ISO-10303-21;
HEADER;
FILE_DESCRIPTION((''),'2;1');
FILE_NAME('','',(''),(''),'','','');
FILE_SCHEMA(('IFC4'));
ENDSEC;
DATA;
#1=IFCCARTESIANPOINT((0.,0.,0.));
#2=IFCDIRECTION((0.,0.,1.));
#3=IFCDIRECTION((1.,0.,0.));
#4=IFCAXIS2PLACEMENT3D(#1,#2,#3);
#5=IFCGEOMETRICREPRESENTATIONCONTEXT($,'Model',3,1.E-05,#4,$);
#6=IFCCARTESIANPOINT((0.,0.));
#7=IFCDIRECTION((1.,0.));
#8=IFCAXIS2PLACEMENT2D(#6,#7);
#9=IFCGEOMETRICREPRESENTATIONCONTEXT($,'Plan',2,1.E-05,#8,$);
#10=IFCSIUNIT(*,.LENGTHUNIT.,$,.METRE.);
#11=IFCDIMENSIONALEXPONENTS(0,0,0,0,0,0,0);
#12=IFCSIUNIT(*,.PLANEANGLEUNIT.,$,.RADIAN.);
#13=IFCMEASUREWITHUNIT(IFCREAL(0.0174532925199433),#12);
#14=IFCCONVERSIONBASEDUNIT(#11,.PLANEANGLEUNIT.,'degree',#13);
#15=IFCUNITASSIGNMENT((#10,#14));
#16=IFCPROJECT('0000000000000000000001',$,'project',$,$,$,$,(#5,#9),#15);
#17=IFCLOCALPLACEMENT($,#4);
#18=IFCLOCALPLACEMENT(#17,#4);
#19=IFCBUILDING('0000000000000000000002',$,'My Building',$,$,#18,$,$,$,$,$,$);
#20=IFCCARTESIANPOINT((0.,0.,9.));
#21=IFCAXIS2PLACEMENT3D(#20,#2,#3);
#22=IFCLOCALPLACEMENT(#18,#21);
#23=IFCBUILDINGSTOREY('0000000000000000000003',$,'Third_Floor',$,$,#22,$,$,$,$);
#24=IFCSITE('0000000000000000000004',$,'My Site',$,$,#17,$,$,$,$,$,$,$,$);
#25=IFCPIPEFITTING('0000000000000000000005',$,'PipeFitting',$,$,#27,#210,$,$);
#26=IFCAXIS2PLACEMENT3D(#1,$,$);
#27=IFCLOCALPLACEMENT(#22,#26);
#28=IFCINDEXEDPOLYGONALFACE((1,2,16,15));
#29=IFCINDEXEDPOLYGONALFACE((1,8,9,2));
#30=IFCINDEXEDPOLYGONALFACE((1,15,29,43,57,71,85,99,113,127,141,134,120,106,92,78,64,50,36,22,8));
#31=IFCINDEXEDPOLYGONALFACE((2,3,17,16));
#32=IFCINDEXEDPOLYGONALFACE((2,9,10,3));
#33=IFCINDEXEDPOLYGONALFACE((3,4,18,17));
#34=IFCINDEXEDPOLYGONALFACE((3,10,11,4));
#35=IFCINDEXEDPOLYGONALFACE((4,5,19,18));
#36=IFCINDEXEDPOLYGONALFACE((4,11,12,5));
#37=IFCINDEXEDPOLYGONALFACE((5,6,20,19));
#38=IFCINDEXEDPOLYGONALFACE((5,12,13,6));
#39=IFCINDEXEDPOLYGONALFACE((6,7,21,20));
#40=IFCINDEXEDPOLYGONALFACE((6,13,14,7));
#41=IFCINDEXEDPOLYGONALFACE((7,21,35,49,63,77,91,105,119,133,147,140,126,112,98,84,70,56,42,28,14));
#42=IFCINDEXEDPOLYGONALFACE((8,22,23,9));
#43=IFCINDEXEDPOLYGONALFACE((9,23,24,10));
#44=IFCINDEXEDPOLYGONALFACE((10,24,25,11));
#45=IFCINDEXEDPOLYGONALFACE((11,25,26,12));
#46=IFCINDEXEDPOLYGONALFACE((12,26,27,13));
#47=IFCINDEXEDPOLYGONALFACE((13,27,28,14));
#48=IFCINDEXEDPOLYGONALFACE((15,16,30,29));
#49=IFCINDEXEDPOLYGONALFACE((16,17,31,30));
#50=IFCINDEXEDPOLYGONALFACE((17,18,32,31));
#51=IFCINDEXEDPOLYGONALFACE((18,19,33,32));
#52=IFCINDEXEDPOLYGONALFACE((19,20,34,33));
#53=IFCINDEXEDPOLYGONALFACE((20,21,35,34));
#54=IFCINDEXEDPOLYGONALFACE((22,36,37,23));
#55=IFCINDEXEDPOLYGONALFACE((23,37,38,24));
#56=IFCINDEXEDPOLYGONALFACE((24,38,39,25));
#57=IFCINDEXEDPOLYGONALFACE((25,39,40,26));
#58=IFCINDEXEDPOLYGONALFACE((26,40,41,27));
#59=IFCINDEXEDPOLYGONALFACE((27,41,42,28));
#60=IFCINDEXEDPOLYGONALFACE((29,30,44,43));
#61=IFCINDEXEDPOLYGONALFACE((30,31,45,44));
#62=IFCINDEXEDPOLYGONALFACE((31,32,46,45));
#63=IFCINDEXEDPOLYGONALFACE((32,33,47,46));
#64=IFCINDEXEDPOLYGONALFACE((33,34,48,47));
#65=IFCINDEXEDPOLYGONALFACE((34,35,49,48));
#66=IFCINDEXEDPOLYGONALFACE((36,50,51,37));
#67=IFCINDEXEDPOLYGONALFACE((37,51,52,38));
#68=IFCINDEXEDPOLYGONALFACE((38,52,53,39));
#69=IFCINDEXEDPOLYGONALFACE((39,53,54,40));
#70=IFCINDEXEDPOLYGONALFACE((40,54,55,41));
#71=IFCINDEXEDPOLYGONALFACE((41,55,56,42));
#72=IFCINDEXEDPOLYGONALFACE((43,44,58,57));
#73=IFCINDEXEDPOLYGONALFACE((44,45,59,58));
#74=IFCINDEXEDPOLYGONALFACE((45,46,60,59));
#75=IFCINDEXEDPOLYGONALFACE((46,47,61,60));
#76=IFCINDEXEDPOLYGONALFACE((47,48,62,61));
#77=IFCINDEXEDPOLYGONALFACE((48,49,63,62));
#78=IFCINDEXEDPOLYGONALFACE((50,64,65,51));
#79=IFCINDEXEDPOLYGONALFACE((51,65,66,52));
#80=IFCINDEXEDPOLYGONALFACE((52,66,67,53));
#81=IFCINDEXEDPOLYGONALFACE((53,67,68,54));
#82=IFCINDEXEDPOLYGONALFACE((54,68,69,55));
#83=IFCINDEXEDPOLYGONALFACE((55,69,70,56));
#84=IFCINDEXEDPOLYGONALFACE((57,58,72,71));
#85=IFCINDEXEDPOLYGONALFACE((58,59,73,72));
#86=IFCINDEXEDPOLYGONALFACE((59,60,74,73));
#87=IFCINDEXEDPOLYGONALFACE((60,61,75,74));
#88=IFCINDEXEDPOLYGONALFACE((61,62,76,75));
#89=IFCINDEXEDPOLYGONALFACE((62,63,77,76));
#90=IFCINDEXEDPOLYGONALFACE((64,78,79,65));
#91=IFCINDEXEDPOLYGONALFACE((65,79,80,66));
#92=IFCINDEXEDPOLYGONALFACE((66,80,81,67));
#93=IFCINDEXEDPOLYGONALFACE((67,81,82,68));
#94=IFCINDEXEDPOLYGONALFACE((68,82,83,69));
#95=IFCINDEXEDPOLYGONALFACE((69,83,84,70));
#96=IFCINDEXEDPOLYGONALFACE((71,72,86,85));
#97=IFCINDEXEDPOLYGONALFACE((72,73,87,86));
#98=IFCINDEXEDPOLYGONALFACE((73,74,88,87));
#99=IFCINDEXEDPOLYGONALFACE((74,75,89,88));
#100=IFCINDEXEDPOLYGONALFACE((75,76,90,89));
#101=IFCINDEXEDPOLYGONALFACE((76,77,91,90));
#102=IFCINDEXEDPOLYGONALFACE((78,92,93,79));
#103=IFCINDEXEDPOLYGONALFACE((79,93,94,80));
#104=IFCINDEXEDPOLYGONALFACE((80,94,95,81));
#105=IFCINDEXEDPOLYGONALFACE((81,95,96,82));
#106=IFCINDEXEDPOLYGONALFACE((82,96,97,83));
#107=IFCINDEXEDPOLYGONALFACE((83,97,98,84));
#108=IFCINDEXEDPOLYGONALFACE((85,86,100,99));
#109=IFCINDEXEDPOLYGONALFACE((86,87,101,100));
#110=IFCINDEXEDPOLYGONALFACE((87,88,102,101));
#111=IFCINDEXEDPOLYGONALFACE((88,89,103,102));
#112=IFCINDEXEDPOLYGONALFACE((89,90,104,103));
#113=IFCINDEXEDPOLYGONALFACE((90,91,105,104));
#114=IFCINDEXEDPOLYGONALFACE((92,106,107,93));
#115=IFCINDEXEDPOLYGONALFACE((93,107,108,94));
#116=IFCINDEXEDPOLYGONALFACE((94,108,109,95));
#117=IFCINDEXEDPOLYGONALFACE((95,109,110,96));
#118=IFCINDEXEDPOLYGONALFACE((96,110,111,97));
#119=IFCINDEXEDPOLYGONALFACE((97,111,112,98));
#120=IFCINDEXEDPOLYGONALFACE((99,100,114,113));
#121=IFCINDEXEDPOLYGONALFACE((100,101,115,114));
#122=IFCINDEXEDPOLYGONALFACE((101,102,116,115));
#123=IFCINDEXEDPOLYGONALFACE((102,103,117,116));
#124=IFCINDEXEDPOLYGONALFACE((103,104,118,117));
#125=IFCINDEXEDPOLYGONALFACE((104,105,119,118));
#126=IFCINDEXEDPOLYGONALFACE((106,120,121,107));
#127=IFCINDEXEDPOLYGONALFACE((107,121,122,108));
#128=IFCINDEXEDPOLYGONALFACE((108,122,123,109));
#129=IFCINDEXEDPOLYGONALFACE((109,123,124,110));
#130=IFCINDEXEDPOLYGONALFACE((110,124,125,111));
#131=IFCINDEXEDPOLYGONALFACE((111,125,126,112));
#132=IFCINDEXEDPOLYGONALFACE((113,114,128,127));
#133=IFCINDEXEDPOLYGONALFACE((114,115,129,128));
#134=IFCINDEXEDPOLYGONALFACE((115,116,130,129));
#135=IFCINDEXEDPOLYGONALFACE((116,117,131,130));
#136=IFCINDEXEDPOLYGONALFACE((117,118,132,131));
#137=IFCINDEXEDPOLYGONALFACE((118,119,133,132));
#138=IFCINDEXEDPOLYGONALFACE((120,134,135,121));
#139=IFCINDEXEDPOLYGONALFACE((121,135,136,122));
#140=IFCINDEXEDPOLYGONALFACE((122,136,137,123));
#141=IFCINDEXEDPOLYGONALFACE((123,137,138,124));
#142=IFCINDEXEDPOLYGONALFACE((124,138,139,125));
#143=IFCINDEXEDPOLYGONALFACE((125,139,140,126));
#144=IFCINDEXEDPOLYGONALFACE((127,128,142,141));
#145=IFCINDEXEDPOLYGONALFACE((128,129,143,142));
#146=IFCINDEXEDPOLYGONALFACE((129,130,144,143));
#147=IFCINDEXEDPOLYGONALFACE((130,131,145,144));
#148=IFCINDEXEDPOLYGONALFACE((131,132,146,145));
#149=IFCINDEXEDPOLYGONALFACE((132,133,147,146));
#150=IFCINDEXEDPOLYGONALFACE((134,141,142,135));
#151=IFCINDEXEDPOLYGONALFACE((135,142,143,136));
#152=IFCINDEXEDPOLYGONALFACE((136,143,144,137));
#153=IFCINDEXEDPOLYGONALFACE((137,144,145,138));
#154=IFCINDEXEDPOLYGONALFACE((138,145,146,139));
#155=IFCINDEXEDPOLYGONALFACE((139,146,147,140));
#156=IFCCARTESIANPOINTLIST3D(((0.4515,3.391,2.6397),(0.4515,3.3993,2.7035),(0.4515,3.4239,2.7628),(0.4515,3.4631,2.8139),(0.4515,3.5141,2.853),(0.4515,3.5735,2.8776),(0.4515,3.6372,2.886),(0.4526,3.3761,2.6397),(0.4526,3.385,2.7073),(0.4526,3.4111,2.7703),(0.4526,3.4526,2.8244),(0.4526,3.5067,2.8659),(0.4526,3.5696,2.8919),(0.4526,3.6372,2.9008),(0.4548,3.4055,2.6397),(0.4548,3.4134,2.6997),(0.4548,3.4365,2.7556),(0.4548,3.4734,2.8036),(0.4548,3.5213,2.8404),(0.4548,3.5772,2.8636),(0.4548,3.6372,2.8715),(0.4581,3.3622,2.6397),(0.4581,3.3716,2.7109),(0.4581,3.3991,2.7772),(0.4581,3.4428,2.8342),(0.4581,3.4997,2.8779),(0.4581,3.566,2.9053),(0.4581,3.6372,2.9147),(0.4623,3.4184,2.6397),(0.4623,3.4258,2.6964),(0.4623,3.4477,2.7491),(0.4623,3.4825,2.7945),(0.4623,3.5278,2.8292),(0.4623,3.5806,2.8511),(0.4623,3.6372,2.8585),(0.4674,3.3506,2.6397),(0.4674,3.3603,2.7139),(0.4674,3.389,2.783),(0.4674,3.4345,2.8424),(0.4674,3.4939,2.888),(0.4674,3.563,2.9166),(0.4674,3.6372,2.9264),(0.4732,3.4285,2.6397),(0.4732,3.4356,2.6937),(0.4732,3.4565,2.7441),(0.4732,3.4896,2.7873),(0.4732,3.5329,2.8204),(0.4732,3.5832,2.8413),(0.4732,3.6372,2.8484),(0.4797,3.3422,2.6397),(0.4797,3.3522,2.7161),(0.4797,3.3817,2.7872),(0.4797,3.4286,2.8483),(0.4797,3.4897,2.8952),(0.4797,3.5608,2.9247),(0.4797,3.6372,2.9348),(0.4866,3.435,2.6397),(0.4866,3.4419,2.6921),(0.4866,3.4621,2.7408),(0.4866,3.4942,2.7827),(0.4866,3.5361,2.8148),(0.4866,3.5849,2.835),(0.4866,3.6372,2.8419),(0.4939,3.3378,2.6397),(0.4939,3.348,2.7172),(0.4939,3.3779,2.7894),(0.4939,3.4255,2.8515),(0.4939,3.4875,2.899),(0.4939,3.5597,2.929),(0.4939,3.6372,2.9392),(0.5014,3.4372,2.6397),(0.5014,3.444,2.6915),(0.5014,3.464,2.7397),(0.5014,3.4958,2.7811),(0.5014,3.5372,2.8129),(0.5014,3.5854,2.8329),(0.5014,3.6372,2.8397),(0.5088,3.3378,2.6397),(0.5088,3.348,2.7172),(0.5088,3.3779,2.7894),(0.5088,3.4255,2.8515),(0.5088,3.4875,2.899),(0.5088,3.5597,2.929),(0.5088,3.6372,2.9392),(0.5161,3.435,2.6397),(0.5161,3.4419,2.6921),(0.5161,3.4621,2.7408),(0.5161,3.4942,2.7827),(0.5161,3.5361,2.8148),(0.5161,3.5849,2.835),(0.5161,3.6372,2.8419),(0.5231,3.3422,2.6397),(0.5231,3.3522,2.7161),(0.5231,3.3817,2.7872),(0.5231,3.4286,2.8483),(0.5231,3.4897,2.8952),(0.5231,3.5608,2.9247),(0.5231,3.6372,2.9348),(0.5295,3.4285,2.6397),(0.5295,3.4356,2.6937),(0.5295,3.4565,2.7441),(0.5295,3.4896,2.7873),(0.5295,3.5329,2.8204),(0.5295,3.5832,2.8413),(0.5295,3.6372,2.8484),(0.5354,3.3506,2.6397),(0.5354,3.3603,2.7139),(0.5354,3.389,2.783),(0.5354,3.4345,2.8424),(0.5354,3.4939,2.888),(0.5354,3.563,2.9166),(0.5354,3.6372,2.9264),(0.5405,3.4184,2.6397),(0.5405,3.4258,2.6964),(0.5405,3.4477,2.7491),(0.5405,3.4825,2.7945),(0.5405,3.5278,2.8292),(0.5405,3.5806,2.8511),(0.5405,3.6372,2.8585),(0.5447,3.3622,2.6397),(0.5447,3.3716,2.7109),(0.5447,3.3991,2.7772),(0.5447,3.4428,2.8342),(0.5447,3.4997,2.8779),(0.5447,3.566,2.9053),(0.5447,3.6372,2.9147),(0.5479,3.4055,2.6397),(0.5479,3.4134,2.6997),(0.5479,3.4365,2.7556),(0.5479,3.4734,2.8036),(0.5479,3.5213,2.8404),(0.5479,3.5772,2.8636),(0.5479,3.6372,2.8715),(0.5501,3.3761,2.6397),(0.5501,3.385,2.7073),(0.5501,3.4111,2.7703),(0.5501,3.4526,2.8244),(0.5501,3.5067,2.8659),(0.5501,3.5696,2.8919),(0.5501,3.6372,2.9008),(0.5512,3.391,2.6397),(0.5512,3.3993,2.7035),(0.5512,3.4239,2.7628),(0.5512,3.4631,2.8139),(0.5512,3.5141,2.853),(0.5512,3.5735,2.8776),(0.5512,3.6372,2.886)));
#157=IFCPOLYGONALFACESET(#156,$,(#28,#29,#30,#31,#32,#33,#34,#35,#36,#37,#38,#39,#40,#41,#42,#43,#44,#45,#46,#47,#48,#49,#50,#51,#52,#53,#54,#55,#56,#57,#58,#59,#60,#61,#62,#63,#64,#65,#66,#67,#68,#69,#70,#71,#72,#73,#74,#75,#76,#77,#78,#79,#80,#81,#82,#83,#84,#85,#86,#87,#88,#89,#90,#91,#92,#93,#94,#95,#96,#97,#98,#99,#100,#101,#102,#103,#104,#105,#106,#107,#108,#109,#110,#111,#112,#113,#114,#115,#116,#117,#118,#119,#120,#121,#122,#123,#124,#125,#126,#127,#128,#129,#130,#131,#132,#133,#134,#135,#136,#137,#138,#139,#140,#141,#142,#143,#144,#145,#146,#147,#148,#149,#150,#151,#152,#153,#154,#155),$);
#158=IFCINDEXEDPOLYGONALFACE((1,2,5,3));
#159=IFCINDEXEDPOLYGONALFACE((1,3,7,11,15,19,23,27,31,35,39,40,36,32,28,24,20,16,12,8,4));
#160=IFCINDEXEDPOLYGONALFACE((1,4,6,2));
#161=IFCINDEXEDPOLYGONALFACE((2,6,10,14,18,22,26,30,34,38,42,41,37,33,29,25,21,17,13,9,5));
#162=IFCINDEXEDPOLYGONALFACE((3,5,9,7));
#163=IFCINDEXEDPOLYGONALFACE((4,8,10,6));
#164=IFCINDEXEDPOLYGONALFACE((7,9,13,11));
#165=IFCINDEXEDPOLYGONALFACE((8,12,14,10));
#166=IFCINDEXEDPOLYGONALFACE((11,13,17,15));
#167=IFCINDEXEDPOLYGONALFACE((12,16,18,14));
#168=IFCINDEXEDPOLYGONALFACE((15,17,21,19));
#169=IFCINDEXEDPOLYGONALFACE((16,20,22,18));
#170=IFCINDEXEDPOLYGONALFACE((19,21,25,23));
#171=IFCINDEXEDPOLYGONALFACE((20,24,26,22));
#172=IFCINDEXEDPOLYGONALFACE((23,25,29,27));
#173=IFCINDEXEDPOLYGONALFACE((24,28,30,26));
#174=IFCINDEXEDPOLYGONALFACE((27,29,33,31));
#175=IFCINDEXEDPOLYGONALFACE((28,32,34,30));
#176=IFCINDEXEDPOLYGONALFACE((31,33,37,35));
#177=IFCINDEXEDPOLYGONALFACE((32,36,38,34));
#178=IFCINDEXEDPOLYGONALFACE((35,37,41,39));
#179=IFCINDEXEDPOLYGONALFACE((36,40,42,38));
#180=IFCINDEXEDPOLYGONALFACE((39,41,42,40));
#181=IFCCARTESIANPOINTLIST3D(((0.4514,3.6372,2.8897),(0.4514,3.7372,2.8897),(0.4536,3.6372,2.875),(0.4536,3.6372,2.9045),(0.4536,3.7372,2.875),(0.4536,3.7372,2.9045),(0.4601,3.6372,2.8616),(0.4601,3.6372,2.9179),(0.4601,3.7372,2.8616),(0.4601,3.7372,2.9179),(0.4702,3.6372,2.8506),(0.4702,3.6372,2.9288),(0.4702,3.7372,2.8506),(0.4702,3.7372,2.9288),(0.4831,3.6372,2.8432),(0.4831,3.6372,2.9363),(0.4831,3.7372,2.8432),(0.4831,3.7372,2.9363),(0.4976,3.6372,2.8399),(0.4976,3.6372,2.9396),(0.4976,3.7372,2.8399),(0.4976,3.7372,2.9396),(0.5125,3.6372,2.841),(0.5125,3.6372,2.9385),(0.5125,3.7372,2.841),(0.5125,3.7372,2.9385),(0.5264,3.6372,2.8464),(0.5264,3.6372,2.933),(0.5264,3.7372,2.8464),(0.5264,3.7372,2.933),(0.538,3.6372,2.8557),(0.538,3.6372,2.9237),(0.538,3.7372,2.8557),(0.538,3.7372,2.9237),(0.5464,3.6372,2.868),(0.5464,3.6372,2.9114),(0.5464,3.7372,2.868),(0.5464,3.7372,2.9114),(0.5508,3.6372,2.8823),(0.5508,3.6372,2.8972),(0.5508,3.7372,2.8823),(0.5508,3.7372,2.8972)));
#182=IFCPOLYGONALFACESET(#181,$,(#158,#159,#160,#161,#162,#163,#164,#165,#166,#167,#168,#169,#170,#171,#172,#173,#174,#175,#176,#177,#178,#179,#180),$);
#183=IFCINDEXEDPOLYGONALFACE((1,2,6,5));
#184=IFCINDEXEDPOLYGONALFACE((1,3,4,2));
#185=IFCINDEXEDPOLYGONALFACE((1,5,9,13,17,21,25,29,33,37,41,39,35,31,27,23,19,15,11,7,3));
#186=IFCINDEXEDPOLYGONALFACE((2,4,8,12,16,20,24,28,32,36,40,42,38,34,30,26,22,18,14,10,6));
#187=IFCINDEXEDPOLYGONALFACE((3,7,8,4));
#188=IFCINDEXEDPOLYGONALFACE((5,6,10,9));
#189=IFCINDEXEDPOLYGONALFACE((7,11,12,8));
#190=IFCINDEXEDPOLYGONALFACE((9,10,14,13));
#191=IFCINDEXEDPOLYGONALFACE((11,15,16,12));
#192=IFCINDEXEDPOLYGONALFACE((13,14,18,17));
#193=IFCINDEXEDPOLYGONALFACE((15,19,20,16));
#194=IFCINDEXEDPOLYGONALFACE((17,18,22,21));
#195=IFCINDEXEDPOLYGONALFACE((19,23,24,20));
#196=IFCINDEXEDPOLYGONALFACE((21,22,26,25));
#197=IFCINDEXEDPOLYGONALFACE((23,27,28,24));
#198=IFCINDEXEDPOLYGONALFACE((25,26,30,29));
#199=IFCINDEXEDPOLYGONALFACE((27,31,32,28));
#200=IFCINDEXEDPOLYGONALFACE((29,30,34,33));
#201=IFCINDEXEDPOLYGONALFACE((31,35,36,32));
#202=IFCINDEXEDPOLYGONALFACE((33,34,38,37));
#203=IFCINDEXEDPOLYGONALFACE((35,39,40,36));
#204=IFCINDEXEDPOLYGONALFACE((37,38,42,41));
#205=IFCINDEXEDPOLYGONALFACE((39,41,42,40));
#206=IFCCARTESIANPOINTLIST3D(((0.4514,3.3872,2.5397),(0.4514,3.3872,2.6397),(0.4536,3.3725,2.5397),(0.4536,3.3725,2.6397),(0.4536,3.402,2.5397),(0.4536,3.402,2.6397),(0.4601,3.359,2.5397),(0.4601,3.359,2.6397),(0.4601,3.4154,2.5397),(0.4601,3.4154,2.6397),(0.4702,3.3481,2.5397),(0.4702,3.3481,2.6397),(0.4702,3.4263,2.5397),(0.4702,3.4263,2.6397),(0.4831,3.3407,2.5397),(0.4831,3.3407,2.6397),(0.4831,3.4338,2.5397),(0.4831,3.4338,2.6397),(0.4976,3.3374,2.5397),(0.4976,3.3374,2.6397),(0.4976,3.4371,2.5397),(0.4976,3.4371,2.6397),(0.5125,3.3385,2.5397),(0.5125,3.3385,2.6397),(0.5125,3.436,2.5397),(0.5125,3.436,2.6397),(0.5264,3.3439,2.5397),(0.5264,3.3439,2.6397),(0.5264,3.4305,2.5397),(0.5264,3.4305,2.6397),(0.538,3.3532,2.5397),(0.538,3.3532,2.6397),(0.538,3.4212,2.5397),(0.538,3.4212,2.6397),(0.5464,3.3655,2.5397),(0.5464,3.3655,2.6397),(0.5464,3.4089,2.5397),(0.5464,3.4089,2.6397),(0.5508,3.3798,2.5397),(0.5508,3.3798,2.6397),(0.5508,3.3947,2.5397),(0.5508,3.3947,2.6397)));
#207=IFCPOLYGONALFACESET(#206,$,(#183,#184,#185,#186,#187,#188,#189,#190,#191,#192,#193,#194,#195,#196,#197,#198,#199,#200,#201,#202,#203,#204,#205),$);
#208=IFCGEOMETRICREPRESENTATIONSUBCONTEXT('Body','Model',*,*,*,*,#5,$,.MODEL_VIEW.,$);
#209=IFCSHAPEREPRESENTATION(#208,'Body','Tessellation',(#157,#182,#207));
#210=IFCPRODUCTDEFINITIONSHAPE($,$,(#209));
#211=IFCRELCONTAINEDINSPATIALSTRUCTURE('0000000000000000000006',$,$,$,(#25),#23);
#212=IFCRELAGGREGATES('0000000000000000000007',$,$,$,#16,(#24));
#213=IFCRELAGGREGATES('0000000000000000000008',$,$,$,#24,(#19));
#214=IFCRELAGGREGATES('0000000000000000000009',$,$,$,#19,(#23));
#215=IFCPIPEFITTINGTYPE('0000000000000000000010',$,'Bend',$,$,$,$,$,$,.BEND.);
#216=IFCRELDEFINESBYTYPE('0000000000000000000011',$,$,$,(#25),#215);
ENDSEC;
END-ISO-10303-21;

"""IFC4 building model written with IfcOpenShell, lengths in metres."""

from ifc_helpers import new_model, entity, si_unit, converted_unit, frame, origin_with_axes, origin_2d_with_axis, place, context, subcontext, project, spatial, circle, extrude, source, transform, mapped, type_object, type_shapes, element, save


model = new_model("IFC4")

# Units and contexts
model_context = context("Model", 3, precision=1e-05, world=origin_with_axes())
plan_context = context("Plan", 2, precision=1e-05, world=origin_2d_with_axis())
body_context_1 = subcontext(model_context, "Body", "Model", "MODEL_VIEW")
ifc_project = project(units=[si_unit("LENGTHUNIT", "METRE"), converted_unit("PLANEANGLEUNIT", "degree", entity("IfcReal", 0.0174532925199433), si_unit("PLANEANGLEUNIT", "RADIAN"), dimensions=[0, 0, 0, 0, 0, 0, 0])], contexts=[model_context, plan_context])

# Site, building, storey
site_placement = place(None, origin_with_axes())
site = spatial("IfcSite", under=ifc_project, at=site_placement, Name="My Site")
building_placement = place(site_placement, origin_with_axes())
building = spatial("IfcBuilding", under=site, at=building_placement, Name="My Building")
storey_placement = place(building_placement, frame((0.0, 0.0, 9.0), z_axis=(0.0, 0.0, 1.0), x_axis=(1.0, 0.0, 0.0)))
storey = spatial("IfcBuildingStorey", under=building, at=storey_placement, Name="Third_Floor")

# Pipe fitting
pipe_fitting_type = type_object("IfcPipeFittingType", Name="Bend", PredefinedType="BEND")
shared_shape_1 = source(origin_with_axes(), body_context_1, "Body", "SolidModel", [
    entity("IfcSweptDiskSolid", entity("IfcIndexedPolyCurve", entity("IfcCartesianPointList3D", [[0.0, 0.0, -0.1], [0.0, -0.0732, -0.2768], [0.0, -0.25, -0.35]]), [entity("IfcArcIndex", [1, 2, 3])]), 0.05),
    extrude(circle(Radius=0.05), origin_with_axes(), (0.0, 0.0, -1.0), 0.1),
    extrude(circle(Radius=0.05), frame((0.0, -0.25, -0.35), z_axis=(0.0, -1.0, 0.0), x_axis=(1.0, 0.0, 0.0)), (0.0, 0.0, 1.0), 0.1),
])
type_shapes(pipe_fitting_type, [shared_shape_1])
for number, where, z_axis, x_axis, name in (
    (1, (0.5014, 3.7372, 2.8897), (0.0, 1.0, 0.0), (-1.0, 0.0, 0.0), "PipeFitting"),
):
    element("IfcPipeFitting", number, at=place(storey_placement, frame(where, z_axis=z_axis, x_axis=x_axis)), inside=storey, type_object=pipe_fitting_type, Name=name, context=body_context_1, shape_type="MappedRepresentation", body=[
        mapped(shared_shape_1, transform((0.0, 0.0, 0.0), x_axis=(1.0, 0.0, 0.0), y_axis=(0.0, 1.0, 0.0), z_axis=(0.0, 0.0, 1.0), scale=1.0)),
    ])

save(model, "model.ifc")
